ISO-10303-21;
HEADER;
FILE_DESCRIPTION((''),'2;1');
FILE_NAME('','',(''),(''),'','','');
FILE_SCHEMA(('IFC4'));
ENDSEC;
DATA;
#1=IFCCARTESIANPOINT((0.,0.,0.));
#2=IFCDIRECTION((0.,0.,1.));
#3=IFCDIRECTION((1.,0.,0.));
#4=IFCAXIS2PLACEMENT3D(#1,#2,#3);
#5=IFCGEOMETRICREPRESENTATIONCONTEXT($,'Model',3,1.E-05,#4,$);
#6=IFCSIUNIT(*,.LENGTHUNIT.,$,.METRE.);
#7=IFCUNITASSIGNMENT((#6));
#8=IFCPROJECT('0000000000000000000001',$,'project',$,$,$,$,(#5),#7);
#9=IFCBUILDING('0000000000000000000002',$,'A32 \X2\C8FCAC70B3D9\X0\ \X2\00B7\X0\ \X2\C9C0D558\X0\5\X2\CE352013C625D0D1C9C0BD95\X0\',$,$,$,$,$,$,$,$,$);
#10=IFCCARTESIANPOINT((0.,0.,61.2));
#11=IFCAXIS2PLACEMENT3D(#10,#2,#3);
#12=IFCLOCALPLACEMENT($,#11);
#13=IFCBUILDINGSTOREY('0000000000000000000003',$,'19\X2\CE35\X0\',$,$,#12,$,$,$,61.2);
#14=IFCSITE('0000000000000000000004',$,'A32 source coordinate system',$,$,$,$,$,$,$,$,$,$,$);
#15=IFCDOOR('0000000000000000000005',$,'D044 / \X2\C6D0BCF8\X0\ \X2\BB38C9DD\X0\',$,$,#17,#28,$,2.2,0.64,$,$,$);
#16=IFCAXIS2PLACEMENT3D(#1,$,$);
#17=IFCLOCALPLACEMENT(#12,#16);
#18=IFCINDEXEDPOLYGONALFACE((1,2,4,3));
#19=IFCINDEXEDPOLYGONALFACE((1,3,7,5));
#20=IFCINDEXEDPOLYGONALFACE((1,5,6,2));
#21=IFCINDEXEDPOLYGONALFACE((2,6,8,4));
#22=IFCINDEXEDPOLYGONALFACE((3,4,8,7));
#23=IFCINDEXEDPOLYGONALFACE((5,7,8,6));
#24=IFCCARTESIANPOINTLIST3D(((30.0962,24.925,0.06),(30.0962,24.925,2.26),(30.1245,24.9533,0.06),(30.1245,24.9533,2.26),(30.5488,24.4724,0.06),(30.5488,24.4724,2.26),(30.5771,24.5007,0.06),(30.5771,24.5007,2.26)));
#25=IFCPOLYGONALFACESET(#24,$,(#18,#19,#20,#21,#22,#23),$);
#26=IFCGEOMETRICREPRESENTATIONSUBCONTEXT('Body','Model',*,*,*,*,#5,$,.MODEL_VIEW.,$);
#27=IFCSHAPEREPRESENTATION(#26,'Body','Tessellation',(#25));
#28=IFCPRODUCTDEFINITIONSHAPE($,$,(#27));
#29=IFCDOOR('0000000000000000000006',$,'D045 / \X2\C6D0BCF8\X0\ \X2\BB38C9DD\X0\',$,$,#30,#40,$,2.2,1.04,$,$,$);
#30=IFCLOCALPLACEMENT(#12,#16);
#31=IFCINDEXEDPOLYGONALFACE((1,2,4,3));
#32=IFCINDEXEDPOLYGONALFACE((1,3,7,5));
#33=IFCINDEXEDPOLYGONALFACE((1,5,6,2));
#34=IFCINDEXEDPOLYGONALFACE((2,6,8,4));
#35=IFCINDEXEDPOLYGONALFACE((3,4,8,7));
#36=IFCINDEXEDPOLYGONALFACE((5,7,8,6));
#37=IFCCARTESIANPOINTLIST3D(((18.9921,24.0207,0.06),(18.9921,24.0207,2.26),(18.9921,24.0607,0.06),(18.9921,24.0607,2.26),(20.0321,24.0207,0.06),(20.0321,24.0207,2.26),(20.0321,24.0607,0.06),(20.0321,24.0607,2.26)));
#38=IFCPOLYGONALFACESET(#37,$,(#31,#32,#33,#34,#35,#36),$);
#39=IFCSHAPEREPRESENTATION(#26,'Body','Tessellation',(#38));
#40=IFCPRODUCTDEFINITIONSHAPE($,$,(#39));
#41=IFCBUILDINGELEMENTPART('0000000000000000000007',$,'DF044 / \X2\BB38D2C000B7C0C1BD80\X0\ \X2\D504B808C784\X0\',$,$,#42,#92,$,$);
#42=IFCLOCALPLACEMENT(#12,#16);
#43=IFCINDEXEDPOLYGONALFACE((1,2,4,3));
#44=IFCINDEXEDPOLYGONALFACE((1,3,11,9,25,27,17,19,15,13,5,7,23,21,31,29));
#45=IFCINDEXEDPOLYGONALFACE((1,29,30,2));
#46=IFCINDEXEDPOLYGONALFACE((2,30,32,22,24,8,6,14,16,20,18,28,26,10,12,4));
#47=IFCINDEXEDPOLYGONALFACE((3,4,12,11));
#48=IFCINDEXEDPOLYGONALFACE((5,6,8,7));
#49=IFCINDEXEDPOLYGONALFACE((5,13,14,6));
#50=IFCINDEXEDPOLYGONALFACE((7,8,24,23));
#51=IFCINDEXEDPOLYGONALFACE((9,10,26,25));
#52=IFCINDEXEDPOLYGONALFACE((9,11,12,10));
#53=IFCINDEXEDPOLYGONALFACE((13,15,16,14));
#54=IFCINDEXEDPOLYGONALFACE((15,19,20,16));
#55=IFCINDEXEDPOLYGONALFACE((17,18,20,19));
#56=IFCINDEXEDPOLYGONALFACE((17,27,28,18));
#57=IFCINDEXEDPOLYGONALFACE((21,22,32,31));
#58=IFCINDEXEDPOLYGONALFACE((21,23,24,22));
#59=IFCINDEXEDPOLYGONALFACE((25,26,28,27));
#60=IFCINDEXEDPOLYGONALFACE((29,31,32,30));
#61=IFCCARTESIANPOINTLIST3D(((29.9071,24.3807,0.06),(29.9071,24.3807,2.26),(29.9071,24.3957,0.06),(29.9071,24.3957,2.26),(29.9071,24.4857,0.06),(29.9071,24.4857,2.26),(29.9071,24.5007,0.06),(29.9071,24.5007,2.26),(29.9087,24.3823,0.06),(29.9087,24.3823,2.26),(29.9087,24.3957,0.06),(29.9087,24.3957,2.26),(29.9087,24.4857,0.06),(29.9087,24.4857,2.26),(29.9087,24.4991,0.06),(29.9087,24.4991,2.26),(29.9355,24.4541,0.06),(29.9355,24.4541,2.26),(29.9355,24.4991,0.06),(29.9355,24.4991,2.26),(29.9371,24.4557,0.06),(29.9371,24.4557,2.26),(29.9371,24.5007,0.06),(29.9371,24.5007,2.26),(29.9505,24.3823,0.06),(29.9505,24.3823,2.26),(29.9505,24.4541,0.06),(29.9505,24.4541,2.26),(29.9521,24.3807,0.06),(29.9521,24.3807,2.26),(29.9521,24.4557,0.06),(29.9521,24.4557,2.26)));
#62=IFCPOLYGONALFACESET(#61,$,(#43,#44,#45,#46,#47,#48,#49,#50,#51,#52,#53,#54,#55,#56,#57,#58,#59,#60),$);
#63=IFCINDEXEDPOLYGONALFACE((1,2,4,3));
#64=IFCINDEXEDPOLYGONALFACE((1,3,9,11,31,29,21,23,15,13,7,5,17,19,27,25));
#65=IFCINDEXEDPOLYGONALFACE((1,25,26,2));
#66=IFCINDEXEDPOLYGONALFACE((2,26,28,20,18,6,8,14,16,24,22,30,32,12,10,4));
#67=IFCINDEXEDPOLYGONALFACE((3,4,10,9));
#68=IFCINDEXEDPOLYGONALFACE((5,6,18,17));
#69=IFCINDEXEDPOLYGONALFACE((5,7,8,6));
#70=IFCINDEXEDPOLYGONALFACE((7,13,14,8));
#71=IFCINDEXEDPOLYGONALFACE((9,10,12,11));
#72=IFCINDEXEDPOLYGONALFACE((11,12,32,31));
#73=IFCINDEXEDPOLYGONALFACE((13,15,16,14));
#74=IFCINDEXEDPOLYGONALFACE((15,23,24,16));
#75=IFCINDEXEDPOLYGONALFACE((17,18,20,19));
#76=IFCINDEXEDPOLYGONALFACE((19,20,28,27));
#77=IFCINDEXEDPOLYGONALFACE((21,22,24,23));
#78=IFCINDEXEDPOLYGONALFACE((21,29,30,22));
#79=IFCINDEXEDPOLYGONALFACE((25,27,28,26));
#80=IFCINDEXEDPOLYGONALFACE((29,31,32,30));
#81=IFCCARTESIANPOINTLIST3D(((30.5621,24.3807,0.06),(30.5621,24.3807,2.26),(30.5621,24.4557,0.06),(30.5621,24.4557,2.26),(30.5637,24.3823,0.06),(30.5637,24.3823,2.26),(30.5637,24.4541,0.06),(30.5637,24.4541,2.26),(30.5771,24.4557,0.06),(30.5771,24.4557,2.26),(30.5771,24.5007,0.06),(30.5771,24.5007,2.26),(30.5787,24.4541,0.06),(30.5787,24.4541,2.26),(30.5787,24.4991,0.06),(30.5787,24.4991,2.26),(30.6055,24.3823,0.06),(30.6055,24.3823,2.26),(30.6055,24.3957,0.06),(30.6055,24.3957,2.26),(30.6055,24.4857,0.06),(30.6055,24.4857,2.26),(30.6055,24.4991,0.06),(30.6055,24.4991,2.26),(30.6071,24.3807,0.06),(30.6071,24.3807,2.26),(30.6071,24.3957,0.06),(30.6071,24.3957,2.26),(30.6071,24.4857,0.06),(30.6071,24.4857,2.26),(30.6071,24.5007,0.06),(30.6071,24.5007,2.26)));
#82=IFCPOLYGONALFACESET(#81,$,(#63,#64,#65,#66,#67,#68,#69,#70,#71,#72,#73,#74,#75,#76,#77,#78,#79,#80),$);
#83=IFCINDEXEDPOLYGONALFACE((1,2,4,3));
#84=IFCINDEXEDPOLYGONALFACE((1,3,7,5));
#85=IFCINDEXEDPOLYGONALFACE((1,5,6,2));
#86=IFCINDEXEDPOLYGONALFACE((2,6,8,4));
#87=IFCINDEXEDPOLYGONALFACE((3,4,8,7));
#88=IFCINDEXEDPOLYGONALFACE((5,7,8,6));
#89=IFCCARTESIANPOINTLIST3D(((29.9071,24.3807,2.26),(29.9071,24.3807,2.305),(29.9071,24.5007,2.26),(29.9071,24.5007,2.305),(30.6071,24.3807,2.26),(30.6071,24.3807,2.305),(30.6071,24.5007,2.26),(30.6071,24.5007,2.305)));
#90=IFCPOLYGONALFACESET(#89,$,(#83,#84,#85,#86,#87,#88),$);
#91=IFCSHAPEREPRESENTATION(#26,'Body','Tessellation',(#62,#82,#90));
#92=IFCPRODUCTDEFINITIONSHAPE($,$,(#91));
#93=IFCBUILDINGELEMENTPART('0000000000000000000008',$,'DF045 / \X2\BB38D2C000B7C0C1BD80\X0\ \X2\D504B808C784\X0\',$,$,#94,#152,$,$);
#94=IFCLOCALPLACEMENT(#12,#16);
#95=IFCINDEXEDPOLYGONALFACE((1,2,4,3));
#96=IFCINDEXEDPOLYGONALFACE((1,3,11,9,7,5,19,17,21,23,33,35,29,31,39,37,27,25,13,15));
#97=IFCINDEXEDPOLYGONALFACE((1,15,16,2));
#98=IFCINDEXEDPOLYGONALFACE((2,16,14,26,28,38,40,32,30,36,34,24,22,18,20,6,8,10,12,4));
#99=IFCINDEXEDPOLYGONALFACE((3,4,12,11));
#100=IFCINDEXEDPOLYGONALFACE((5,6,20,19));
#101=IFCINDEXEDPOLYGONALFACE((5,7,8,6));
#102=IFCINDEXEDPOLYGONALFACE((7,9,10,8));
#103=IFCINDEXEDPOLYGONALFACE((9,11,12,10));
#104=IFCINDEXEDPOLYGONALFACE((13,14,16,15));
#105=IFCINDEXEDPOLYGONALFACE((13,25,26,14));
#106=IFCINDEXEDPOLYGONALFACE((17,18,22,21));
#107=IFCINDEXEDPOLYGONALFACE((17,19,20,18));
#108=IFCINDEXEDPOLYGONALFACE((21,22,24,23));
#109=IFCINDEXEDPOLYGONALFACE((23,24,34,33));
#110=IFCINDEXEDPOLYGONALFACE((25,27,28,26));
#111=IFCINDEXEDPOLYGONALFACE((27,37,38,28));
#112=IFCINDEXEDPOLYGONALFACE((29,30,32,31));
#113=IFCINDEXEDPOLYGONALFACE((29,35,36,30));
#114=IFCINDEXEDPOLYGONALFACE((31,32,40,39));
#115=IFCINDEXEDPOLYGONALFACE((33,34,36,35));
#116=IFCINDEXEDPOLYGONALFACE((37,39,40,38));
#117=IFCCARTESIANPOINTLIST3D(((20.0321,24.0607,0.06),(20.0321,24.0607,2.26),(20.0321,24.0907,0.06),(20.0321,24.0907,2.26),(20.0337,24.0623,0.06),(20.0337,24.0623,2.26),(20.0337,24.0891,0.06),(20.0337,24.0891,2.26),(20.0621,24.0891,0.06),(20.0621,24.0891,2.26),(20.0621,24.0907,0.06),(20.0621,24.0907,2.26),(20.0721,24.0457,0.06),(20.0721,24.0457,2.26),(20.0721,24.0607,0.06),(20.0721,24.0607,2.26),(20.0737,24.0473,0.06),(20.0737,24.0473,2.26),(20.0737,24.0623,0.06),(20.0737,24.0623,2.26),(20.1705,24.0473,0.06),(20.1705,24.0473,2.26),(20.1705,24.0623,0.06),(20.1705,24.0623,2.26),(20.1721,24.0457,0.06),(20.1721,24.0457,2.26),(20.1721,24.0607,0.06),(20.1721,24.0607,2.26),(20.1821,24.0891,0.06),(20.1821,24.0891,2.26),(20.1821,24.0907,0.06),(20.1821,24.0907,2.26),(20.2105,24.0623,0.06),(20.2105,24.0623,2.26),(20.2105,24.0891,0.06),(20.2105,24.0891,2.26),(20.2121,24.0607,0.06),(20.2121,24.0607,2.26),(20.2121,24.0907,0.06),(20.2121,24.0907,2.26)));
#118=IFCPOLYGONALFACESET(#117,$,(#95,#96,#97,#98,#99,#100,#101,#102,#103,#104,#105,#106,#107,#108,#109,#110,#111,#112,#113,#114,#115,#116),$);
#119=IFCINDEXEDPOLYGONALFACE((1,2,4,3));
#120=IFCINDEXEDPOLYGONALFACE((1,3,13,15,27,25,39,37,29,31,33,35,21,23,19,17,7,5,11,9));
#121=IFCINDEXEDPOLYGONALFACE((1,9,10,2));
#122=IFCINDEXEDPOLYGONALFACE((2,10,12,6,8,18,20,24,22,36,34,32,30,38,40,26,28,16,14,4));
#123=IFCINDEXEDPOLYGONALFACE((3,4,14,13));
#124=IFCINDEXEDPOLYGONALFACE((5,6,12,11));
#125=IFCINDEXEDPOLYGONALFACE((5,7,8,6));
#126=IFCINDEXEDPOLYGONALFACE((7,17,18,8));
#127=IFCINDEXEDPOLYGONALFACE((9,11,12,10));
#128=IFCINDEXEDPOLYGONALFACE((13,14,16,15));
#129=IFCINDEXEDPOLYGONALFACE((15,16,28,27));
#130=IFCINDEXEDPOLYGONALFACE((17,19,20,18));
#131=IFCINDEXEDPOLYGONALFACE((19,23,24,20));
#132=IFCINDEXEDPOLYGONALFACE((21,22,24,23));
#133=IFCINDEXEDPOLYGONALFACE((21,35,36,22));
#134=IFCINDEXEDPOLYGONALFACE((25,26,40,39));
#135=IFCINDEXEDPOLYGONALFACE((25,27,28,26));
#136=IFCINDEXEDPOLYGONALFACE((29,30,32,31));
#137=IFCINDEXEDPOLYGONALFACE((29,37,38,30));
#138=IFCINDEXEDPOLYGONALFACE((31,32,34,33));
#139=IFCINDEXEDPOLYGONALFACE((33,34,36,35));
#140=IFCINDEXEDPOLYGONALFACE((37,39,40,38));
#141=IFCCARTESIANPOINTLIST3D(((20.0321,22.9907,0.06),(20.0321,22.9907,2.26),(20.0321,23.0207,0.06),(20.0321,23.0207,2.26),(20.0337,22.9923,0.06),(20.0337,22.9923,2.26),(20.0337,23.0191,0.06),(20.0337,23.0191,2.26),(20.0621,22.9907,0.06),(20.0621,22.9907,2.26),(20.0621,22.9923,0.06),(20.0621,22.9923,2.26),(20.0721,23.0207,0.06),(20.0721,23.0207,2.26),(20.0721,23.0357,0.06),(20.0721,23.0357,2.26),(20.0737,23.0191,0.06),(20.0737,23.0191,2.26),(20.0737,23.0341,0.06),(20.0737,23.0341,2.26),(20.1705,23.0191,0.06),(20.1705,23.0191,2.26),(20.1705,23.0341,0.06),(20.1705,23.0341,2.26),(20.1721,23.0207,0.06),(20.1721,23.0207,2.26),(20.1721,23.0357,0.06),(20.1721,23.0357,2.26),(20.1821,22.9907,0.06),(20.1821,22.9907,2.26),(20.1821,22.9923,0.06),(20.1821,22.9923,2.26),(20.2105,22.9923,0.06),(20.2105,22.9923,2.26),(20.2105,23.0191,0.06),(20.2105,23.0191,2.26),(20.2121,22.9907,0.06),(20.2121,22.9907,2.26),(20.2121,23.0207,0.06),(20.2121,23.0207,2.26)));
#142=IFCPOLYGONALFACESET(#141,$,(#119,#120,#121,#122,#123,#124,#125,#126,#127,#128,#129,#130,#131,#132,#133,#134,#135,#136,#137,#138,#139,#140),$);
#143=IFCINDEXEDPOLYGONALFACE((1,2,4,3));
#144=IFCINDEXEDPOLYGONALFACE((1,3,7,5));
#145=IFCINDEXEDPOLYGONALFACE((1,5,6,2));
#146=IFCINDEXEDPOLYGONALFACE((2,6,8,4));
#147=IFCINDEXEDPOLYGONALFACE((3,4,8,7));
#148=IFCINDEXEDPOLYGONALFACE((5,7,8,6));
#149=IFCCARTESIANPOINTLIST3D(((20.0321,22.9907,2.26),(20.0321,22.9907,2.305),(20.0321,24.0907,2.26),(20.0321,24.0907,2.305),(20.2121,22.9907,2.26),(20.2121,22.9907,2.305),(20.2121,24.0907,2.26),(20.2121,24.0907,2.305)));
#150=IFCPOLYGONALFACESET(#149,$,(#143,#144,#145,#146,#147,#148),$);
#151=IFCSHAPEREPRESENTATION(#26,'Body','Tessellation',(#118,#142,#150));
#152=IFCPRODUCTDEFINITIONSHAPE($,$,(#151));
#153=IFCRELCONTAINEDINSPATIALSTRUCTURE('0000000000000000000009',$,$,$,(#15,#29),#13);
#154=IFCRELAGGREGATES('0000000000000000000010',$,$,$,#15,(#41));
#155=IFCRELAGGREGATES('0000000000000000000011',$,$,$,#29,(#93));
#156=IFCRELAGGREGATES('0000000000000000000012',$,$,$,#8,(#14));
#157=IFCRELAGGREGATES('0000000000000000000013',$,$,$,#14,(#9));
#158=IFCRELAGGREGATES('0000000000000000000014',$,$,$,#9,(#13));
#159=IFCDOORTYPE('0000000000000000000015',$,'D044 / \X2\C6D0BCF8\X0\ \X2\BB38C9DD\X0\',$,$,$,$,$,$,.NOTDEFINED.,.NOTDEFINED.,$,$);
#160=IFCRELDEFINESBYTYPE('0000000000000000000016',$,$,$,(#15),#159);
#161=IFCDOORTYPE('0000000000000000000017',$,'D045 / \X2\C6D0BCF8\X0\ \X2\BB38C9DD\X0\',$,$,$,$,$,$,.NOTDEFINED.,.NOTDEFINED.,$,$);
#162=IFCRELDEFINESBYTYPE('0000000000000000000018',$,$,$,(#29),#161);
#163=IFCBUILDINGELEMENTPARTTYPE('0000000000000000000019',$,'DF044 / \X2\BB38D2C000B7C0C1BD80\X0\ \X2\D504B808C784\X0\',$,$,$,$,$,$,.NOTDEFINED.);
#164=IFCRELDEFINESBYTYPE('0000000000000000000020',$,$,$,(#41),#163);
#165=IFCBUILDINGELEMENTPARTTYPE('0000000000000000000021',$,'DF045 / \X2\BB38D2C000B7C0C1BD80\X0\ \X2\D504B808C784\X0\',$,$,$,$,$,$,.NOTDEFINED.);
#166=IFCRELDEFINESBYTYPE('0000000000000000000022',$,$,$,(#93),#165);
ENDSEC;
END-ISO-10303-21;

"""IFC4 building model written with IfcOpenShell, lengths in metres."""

from ifc_helpers import new_model, si_unit, frame, origin, origin_with_axes, place, context, subcontext, project, spatial, polyline, outline, extrude, source, transform, mapped, type_object, type_shapes, element, aggregate, save


model = new_model("IFC4")

# Units and contexts
model_context = context("Model", 3, precision=1e-05, world=origin_with_axes())
body_context = subcontext(model_context, "Body", "Model", "MODEL_VIEW")
ifc_project = project(units=[si_unit("LENGTHUNIT", "METRE")], contexts=[model_context])

# Site, building, storey
storey_placement = place(None, frame((0.0, 0.0, 61.2), z_axis=(0.0, 0.0, 1.0), x_axis=(1.0, 0.0, 0.0)))
site = spatial("IfcSite", under=ifc_project, Name="A32 source coordinate system")
building = spatial("IfcBuilding", under=site, Name="A32 주거동 · 지하5층–옥탑지붕")
storey = spatial("IfcBuildingStorey", under=building, at=storey_placement, Name="19층", Elevation=61.2)

# Doors
door_type_1 = type_object("IfcDoorType", Name="D044 / 원본 문짝", OperationType="NOTDEFINED", PredefinedType="NOTDEFINED")
shared_shape_1 = source(origin(), body_context, "Body", "SweptSolid", [
    extrude(outline(polyline([(30.5771, 24.5007), (30.5488, 24.4724), (30.0962, 24.925), (30.1245, 24.9533), (30.5771, 24.5007)])), frame((0.0, 0.0, 0.06)), (0.0, 0.0, 1.0), 2.2),
])
type_shapes(door_type_1, [shared_shape_1])
door_1_placement = place(storey_placement, origin_with_axes())
door_1 = element("IfcDoor", 1, at=door_1_placement, inside=storey, type_object=door_type_1, Name="D044 / 원본 문짝", OverallHeight=2.2, OverallWidth=0.64, context=body_context, shape_type="MappedRepresentation", body=[
    mapped(shared_shape_1, transform((0.0, 0.0, 0.0), scale=1.0)),
])
door_type_2 = type_object("IfcDoorType", Name="D045 / 원본 문짝", OperationType="NOTDEFINED", PredefinedType="NOTDEFINED")
shared_shape_2 = source(origin(), body_context, "Body", "SweptSolid", [
    extrude(outline(polyline([(20.0321, 24.0607), (20.0321, 24.0207), (18.9921, 24.0207), (18.9921, 24.0607), (20.0321, 24.0607)])), frame((0.0, 0.0, 0.06)), (0.0, 0.0, 1.0), 2.2),
])
type_shapes(door_type_2, [shared_shape_2])
door_2_placement = place(storey_placement, origin_with_axes())
door_2 = element("IfcDoor", 2, at=door_2_placement, inside=storey, type_object=door_type_2, Name="D045 / 원본 문짝", OverallHeight=2.2, OverallWidth=1.04, context=body_context, shape_type="MappedRepresentation", body=[
    mapped(shared_shape_2, transform((0.0, 0.0, 0.0), scale=1.0)),
])

# Building element parts
building_element_part_type_1 = type_object("IfcBuildingElementPartType", Name="DF044 / 문틀·상부 프레임", PredefinedType="NOTDEFINED")
shared_shape_3 = source(origin(), body_context, "Body", "SweptSolid", [
    extrude(outline(polyline([(29.9071, 24.4857), (29.9071, 24.5007), (29.9371, 24.5007), (29.9371, 24.4557), (29.9521, 24.4557), (29.9521, 24.3807), (29.9071, 24.3807), (29.9071, 24.3957), (29.9087, 24.3957), (29.9087, 24.3823), (29.9505, 24.3823), (29.9505, 24.4541), (29.9355, 24.4541), (29.9355, 24.4991), (29.9087, 24.4991), (29.9087, 24.4857), (29.9071, 24.4857)])), frame((0.0, 0.0, 0.06)), (0.0, 0.0, 1.0), 2.2),
    extrude(outline(polyline([(30.6055, 24.4991), (30.5787, 24.4991), (30.5787, 24.4541), (30.5637, 24.4541), (30.5637, 24.3823), (30.6055, 24.3823), (30.6055, 24.3957), (30.6071, 24.3957), (30.6071, 24.3807), (30.5621, 24.3807), (30.5621, 24.4557), (30.5771, 24.4557), (30.5771, 24.5007), (30.6071, 24.5007), (30.6071, 24.4857), (30.6055, 24.4857), (30.6055, 24.4991)])), frame((0.0, 0.0, 0.06)), (0.0, 0.0, 1.0), 2.2),
    extrude(outline(polyline([(29.9071, 24.3807), (29.9071, 24.5007), (30.6071, 24.5007), (30.6071, 24.3807), (29.9071, 24.3807)])), frame((0.0, 0.0, 2.26)), (0.0, 0.0, 1.0), 0.045),
])
type_shapes(building_element_part_type_1, [shared_shape_3])
building_element_part_1_placement = place(door_1_placement, origin_with_axes())
building_element_part_1 = element("IfcBuildingElementPart", 3, at=building_element_part_1_placement, type_object=building_element_part_type_1, Name="DF044 / 문틀·상부 프레임", context=body_context, shape_type="MappedRepresentation", body=[
    mapped(shared_shape_3, transform((0.0, 0.0, 0.0), scale=1.0)),
])
aggregate(door_1, [building_element_part_1])
building_element_part_type_2 = type_object("IfcBuildingElementPartType", Name="DF045 / 문틀·상부 프레임", PredefinedType="NOTDEFINED")
shared_shape_4 = source(origin(), body_context, "Body", "SweptSolid", [
    extrude(outline(polyline([(20.0337, 24.0891), (20.0337, 24.0623), (20.0737, 24.0623), (20.0737, 24.0473), (20.1705, 24.0473), (20.1705, 24.0623), (20.2105, 24.0623), (20.2105, 24.0891), (20.1821, 24.0891), (20.1821, 24.0907), (20.2121, 24.0907), (20.2121, 24.0607), (20.1721, 24.0607), (20.1721, 24.0457), (20.0721, 24.0457), (20.0721, 24.0607), (20.0321, 24.0607), (20.0321, 24.0907), (20.0621, 24.0907), (20.0621, 24.0891), (20.0337, 24.0891)])), frame((0.0, 0.0, 0.06)), (0.0, 0.0, 1.0), 2.2),
    extrude(outline(polyline([(20.0621, 22.9907), (20.0321, 22.9907), (20.0321, 23.0207), (20.0721, 23.0207), (20.0721, 23.0357), (20.1721, 23.0357), (20.1721, 23.0207), (20.2121, 23.0207), (20.2121, 22.9907), (20.1821, 22.9907), (20.1821, 22.9923), (20.2105, 22.9923), (20.2105, 23.0191), (20.1705, 23.0191), (20.1705, 23.0341), (20.0737, 23.0341), (20.0737, 23.0191), (20.0337, 23.0191), (20.0337, 22.9923), (20.0621, 22.9923), (20.0621, 22.9907)])), frame((0.0, 0.0, 0.06)), (0.0, 0.0, 1.0), 2.2),
    extrude(outline(polyline([(20.0321, 22.9907), (20.0321, 24.0907), (20.2121, 24.0907), (20.2121, 22.9907), (20.0321, 22.9907)])), frame((0.0, 0.0, 2.26)), (0.0, 0.0, 1.0), 0.045),
])
type_shapes(building_element_part_type_2, [shared_shape_4])
building_element_part_2_placement = place(door_2_placement, origin_with_axes())
building_element_part_2 = element("IfcBuildingElementPart", 4, at=building_element_part_2_placement, type_object=building_element_part_type_2, Name="DF045 / 문틀·상부 프레임", context=body_context, shape_type="MappedRepresentation", body=[
    mapped(shared_shape_4, transform((0.0, 0.0, 0.0), scale=1.0)),
])
aggregate(door_2, [building_element_part_2])

save(model, "model.ifc")
